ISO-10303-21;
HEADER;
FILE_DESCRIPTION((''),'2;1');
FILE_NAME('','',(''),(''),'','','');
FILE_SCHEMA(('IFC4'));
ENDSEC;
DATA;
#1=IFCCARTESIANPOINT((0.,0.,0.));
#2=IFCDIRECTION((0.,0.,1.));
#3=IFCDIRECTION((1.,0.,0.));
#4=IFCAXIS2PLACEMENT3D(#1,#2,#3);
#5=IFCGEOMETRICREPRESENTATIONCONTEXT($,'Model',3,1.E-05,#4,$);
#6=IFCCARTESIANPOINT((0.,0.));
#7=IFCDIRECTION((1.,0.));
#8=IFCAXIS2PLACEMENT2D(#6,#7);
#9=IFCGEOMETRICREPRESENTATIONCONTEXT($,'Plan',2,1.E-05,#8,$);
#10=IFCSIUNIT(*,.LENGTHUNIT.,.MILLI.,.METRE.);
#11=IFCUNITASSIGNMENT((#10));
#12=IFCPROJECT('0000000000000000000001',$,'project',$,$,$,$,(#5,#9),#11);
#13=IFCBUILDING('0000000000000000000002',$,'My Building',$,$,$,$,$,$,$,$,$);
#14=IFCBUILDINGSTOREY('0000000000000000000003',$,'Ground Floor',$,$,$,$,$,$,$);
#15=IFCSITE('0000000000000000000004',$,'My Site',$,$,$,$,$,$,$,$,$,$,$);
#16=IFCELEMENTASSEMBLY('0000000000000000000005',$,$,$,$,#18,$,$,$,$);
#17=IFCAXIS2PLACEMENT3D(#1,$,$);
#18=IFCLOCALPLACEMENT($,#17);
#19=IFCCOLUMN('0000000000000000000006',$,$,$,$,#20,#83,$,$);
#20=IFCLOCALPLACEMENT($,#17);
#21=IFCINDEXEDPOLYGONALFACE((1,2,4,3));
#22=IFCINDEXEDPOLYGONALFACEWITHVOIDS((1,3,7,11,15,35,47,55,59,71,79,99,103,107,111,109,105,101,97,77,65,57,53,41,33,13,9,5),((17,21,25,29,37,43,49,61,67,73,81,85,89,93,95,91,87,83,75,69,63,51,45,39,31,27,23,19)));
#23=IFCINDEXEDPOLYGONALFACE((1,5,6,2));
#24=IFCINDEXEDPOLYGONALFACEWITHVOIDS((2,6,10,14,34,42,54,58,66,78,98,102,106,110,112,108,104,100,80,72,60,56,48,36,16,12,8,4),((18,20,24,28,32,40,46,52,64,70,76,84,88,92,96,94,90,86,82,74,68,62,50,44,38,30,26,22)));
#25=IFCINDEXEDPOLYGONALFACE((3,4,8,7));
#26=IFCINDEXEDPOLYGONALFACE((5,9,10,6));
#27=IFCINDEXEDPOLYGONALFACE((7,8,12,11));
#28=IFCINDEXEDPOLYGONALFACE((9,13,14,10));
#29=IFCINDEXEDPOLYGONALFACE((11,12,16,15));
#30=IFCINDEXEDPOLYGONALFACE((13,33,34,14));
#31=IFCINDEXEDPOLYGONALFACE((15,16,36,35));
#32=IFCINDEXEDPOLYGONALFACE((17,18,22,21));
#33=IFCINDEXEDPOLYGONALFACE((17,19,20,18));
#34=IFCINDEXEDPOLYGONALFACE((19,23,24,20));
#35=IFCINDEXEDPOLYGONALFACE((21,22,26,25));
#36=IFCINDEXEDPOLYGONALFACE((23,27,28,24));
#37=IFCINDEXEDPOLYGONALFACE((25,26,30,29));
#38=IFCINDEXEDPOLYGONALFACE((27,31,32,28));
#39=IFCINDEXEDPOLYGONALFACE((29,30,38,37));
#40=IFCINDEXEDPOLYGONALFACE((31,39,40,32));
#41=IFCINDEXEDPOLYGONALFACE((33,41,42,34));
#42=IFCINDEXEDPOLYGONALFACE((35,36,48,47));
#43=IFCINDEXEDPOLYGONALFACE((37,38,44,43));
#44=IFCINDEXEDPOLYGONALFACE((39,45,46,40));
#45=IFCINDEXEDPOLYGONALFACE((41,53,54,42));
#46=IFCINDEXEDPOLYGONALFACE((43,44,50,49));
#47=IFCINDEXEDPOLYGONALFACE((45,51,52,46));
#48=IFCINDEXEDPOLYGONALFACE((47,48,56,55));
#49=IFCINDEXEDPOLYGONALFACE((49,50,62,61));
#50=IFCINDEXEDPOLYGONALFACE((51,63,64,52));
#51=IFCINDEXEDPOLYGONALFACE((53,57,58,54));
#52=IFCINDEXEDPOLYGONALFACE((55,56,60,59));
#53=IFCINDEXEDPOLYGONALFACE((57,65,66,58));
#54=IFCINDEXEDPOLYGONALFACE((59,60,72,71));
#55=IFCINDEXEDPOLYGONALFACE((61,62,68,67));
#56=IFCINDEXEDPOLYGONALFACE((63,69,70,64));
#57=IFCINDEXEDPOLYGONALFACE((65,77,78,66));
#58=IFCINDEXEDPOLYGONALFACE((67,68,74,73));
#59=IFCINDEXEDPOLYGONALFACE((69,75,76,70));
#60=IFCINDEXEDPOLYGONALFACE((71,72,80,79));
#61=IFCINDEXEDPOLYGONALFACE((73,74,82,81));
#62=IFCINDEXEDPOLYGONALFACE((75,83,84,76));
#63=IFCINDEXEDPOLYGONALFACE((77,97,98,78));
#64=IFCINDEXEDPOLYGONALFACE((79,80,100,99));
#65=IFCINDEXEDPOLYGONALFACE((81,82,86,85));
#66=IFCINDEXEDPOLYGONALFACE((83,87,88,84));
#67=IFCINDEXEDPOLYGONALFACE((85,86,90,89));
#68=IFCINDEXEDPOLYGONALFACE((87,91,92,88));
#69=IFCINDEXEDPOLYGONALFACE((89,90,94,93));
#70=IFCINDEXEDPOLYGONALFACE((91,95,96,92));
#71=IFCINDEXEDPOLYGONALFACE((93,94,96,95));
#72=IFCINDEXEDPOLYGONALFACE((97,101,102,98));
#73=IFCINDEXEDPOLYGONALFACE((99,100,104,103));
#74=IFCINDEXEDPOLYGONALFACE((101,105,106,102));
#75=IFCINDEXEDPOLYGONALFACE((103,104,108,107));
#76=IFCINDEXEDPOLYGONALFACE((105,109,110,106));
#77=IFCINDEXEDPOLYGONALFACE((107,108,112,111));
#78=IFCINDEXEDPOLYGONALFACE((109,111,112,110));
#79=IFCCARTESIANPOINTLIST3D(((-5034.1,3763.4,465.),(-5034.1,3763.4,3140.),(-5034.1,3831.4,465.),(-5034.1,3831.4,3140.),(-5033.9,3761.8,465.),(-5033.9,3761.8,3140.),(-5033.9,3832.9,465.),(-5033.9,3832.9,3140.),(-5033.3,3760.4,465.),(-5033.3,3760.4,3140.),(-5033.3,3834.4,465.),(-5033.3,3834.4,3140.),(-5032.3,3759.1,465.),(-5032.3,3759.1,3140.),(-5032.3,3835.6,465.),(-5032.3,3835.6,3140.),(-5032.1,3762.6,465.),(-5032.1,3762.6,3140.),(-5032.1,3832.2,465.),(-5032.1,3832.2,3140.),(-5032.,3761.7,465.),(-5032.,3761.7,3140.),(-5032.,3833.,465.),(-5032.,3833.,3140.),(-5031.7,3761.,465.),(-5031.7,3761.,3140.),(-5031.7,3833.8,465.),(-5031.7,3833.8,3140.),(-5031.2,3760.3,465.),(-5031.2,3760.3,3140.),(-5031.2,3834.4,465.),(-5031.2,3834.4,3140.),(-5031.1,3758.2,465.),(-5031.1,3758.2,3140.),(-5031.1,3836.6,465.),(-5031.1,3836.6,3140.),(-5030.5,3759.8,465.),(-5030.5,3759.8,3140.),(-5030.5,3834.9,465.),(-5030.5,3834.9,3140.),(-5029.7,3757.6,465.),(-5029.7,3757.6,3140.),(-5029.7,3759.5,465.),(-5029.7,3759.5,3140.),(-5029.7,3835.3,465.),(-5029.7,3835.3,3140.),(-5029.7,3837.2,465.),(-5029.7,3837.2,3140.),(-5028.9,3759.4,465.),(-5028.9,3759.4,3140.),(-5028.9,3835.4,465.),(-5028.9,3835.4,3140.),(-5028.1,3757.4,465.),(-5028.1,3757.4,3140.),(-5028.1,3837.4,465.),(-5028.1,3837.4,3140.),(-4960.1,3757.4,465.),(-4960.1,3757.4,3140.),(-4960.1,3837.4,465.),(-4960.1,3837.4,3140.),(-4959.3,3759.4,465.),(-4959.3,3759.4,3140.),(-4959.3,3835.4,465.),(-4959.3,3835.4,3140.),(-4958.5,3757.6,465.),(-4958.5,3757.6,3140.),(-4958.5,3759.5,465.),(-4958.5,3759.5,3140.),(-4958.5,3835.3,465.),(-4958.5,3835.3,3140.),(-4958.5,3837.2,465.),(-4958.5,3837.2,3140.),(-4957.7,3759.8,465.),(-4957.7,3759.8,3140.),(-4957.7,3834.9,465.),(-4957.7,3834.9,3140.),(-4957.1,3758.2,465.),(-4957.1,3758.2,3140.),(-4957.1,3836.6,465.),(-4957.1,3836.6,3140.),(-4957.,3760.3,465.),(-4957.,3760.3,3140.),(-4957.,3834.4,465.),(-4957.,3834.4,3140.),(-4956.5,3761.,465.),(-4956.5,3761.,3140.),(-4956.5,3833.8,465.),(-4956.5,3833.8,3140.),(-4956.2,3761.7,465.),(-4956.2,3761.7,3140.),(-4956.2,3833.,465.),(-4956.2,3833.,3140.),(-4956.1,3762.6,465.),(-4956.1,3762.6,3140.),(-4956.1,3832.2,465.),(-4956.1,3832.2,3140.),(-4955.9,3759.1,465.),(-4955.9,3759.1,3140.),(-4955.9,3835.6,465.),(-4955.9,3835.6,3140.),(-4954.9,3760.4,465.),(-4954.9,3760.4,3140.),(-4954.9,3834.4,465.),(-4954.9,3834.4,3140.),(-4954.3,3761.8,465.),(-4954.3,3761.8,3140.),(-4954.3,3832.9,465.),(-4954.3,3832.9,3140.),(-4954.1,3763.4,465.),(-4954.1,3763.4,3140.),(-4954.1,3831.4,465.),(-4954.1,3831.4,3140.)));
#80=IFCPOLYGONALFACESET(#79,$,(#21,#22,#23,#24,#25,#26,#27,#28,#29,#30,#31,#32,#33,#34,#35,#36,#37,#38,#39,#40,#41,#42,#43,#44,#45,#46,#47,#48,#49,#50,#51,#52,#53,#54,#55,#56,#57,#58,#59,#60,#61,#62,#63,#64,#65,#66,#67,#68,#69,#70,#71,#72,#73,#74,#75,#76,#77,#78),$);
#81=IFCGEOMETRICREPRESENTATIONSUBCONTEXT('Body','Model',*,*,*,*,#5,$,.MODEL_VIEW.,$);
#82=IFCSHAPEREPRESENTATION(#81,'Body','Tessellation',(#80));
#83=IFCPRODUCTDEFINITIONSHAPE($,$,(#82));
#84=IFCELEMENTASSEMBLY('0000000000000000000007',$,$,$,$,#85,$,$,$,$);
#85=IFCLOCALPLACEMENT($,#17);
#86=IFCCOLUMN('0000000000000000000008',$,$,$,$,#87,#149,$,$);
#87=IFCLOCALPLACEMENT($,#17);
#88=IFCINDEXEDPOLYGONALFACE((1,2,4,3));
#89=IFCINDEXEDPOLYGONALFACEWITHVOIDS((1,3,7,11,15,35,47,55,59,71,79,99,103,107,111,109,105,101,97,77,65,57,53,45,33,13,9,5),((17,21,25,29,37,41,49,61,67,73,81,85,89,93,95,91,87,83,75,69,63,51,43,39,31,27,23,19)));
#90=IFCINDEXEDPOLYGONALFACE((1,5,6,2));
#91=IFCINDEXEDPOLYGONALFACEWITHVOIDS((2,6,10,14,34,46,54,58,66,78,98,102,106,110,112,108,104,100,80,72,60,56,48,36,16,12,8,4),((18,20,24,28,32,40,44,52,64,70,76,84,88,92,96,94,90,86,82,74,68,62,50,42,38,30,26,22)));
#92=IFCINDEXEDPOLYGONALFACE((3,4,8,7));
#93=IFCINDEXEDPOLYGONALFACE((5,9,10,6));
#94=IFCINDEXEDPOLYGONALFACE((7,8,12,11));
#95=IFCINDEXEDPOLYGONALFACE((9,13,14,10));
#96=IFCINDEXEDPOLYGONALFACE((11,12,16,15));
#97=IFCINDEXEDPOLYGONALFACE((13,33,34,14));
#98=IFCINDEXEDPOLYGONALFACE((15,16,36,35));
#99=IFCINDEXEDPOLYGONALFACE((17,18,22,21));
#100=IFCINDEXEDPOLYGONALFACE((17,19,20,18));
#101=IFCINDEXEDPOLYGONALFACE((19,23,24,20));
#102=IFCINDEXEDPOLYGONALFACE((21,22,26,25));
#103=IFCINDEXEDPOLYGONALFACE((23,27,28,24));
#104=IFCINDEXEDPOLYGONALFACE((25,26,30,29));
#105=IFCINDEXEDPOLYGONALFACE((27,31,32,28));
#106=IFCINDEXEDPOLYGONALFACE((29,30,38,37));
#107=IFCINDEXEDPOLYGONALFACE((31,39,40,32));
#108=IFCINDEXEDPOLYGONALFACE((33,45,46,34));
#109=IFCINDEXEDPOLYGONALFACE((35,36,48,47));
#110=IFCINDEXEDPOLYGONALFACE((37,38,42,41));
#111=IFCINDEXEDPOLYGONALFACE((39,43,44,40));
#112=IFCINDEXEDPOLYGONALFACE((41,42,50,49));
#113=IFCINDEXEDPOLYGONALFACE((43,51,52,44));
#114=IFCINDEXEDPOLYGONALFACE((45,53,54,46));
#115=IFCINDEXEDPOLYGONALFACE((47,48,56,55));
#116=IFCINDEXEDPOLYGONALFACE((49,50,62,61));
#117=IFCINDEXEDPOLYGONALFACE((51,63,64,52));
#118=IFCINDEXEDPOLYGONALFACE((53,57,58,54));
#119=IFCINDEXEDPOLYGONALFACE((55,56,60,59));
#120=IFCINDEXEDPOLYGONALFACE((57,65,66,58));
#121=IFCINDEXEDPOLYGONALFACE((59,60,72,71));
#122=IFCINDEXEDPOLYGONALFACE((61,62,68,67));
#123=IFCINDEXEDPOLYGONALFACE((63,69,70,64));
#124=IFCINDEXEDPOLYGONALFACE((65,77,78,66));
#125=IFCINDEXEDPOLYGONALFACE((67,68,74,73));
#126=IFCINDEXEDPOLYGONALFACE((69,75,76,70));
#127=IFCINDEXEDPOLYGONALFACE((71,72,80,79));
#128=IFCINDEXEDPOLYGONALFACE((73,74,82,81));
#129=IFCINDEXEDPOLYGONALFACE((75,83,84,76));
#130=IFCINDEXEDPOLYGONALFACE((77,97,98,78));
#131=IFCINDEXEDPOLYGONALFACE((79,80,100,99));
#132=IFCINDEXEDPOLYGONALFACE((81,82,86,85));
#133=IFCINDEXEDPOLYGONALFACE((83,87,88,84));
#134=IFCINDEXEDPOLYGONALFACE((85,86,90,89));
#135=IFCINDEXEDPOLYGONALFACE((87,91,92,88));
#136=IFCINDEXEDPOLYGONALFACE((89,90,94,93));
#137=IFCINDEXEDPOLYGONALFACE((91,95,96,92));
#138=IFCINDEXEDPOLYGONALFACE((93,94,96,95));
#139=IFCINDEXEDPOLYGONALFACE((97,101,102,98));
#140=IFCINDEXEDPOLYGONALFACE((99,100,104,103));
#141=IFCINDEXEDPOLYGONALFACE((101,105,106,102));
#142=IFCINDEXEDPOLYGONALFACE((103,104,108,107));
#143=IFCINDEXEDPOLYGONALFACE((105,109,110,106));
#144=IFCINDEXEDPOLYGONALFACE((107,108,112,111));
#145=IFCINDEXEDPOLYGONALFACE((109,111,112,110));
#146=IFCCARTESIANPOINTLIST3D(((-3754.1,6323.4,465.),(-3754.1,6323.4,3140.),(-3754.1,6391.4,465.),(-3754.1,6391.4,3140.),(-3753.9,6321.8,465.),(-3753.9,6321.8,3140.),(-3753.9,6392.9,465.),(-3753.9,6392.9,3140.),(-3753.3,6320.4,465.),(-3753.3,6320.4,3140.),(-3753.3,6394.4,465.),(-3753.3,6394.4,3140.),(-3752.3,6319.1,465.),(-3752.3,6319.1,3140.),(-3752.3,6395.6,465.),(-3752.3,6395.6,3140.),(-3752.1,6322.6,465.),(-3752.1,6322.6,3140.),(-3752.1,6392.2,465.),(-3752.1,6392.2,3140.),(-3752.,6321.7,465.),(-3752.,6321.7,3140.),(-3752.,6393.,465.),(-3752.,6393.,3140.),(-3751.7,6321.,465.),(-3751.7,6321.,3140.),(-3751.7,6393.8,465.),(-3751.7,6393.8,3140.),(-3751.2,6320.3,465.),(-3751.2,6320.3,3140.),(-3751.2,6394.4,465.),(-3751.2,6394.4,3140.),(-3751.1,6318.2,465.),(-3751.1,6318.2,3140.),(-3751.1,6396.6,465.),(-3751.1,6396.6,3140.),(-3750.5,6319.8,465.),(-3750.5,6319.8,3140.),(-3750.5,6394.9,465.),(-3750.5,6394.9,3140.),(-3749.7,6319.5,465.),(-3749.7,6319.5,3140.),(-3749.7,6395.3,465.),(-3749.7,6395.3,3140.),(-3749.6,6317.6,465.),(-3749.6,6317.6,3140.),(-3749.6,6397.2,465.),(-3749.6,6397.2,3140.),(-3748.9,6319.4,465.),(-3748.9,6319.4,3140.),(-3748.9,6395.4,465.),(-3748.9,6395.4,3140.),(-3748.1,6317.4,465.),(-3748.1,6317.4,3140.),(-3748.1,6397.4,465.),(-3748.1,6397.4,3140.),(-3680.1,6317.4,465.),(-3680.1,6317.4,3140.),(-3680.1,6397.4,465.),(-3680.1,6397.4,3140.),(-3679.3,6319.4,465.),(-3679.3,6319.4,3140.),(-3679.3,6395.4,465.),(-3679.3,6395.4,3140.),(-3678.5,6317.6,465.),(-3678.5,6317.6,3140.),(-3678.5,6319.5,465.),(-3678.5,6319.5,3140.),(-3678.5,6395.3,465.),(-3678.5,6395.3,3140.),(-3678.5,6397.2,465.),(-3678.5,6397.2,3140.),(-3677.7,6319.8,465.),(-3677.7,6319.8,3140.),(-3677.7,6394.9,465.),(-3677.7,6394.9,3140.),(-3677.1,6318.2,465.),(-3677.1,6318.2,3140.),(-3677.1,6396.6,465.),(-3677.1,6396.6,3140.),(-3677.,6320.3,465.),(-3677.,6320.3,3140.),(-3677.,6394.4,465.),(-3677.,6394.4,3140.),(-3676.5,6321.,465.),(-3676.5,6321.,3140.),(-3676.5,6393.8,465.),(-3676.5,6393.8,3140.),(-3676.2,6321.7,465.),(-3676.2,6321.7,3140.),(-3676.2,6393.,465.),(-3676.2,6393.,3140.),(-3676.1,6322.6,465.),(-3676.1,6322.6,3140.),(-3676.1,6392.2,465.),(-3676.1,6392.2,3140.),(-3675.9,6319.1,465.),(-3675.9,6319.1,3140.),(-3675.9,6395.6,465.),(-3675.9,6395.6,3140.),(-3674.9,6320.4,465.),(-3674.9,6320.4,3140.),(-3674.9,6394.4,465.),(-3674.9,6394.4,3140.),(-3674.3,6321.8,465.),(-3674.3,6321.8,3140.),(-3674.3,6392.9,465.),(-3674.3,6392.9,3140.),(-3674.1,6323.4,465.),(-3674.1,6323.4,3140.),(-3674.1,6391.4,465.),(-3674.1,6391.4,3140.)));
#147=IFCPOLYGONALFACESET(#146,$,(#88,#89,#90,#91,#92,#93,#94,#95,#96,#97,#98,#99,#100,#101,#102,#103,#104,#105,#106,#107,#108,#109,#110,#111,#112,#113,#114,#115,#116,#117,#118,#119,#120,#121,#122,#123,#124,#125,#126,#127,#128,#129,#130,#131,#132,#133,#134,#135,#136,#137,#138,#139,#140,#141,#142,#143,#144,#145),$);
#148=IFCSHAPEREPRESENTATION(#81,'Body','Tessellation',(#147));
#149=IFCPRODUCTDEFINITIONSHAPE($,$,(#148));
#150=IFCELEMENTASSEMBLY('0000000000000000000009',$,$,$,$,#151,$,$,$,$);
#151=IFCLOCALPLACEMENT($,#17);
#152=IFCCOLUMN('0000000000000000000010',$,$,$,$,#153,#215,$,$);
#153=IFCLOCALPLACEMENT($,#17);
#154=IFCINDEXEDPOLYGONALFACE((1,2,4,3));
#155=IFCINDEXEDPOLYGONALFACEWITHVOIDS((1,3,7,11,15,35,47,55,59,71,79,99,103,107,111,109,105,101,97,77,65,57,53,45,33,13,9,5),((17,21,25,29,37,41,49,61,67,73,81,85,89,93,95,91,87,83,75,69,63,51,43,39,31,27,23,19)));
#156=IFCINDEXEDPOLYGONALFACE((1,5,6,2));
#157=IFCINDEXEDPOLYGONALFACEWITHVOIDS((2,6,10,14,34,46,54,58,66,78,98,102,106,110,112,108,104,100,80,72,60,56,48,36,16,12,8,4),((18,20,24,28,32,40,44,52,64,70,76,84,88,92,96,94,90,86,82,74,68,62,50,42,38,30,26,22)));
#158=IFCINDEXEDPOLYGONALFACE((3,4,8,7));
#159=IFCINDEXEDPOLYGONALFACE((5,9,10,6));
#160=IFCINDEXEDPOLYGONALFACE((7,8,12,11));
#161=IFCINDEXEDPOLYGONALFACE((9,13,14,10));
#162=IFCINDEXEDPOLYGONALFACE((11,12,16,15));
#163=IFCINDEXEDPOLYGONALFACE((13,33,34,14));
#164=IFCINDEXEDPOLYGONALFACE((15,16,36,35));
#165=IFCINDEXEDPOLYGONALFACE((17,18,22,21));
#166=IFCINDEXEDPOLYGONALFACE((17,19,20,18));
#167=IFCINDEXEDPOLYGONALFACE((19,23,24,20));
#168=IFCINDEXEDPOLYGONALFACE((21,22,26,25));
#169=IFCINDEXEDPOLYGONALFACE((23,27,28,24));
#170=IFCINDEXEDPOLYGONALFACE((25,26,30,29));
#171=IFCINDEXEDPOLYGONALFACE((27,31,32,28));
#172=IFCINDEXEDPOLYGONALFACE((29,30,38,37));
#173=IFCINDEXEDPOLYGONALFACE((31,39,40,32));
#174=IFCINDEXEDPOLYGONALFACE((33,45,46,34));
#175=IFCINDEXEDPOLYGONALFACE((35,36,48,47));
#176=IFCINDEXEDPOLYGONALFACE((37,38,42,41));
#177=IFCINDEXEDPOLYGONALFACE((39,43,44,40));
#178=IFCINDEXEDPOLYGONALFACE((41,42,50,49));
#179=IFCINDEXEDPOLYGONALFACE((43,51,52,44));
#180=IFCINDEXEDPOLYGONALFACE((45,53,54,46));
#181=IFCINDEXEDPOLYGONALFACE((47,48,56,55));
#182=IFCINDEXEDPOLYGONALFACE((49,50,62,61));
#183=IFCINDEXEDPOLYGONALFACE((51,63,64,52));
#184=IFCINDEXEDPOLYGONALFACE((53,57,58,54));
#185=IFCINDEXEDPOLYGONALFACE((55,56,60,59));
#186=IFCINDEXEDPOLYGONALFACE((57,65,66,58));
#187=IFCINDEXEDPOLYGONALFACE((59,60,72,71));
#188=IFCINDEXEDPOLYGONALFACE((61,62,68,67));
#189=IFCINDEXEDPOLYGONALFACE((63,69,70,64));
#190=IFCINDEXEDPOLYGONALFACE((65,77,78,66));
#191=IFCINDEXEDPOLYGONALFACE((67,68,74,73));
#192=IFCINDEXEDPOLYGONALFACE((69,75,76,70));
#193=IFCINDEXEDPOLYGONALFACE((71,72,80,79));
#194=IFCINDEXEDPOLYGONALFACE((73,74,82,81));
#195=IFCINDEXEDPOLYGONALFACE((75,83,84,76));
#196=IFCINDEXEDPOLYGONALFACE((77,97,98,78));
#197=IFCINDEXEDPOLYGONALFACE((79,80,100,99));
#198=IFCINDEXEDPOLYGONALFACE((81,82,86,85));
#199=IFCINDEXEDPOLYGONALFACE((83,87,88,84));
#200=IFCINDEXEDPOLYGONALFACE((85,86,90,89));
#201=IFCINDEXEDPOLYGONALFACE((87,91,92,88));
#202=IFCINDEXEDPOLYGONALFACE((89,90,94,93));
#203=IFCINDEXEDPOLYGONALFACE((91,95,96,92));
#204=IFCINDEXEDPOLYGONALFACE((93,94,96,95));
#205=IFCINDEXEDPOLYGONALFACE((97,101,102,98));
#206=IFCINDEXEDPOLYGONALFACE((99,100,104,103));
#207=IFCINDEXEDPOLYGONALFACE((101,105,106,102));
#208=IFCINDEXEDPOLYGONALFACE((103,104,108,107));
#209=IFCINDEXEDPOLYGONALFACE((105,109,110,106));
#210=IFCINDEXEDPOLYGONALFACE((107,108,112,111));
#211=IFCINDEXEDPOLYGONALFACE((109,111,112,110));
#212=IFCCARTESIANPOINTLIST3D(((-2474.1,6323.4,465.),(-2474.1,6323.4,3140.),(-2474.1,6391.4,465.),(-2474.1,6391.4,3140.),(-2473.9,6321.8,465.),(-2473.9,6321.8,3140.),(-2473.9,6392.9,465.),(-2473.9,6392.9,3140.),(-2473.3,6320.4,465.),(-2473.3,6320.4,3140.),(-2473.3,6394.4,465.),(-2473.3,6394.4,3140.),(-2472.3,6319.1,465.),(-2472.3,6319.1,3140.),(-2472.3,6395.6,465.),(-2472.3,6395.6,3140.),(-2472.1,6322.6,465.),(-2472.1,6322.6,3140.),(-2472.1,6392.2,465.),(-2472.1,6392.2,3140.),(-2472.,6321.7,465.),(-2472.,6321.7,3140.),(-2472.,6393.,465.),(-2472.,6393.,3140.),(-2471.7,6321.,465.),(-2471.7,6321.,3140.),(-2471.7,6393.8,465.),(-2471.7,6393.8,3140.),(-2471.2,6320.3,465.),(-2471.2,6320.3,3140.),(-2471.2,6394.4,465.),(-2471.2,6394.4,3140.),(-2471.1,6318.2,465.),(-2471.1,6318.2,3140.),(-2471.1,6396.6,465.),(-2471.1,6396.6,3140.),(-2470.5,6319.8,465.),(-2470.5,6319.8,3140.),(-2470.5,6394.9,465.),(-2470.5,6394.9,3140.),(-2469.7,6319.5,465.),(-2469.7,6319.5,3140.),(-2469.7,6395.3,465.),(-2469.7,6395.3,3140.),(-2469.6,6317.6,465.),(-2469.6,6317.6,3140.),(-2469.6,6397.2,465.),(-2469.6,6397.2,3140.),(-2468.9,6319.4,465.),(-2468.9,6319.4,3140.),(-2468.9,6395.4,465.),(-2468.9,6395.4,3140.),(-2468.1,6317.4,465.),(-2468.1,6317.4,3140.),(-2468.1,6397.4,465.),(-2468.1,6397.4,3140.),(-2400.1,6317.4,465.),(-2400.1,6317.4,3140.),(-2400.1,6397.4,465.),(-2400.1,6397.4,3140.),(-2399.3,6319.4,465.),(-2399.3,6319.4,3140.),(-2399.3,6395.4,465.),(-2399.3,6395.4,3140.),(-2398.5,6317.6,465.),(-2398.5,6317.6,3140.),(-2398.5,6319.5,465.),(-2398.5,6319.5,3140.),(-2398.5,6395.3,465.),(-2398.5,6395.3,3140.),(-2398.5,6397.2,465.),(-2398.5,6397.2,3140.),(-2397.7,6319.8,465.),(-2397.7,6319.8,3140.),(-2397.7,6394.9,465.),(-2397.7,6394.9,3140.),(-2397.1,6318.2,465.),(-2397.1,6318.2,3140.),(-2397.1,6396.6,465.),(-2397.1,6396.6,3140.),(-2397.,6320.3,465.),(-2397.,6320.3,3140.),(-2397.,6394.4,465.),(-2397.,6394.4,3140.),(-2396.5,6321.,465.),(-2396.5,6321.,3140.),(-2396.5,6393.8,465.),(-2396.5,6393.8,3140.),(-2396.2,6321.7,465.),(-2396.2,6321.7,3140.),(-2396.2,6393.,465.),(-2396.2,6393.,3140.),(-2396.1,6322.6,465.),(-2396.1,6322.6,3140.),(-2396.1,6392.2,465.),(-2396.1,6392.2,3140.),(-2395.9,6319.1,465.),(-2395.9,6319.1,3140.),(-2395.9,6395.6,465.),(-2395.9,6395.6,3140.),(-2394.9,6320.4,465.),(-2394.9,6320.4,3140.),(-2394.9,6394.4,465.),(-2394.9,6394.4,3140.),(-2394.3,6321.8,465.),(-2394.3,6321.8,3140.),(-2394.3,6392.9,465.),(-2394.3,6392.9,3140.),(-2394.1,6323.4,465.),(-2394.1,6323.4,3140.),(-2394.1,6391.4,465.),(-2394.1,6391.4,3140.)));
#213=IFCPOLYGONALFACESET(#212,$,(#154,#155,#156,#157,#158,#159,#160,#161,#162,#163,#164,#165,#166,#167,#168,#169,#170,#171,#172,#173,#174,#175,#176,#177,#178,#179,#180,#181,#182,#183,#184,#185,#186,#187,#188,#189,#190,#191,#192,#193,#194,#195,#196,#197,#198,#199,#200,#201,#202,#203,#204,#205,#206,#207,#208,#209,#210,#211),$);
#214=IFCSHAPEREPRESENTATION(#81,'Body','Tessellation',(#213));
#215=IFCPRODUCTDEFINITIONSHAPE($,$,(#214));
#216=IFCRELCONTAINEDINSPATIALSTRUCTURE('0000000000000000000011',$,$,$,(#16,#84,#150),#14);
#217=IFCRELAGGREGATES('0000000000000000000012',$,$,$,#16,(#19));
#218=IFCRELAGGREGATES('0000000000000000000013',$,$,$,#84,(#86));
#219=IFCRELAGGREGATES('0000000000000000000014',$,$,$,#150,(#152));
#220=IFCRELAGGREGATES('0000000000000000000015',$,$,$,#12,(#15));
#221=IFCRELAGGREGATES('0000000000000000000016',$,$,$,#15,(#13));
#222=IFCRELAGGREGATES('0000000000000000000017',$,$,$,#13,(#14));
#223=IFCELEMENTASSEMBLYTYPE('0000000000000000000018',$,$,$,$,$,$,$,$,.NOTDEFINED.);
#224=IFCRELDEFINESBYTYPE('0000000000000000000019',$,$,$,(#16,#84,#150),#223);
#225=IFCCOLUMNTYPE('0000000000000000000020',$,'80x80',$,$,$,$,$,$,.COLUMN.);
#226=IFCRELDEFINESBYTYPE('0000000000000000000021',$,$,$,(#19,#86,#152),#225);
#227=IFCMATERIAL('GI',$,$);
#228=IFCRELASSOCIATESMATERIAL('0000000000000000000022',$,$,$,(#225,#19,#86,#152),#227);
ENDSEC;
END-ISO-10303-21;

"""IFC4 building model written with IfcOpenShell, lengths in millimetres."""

from ifc_helpers import new_model, si_unit, frame, origin_with_axes, origin_2d_with_axis, place, context, subcontext, project, spatial, hollow_rectangle, extrude, material, material_profile, profile_set, profile_usage, type_object, element, aggregate, save


model = new_model("IFC4")

# Units and contexts
model_context = context("Model", 3, precision=1e-05, world=origin_with_axes())
plan_context = context("Plan", 2, precision=1e-05, world=origin_2d_with_axis())
body_context = subcontext(model_context, "Body", "Model", "MODEL_VIEW")
ifc_project = project(units=[si_unit("LENGTHUNIT", "METRE", prefix="MILLI")], contexts=[model_context, plan_context])

# Site, building, storey
site = spatial("IfcSite", under=ifc_project, Name="My Site")
building = spatial("IfcBuilding", under=site, Name="My Building")
storey = spatial("IfcBuildingStorey", under=building, Name="Ground Floor")

# Element assemblies, columns
element_assembly_type_1 = type_object("IfcElementAssemblyType", PredefinedType="NOTDEFINED")
ifc_material = material(Name="GI")
ifc_material_profile_1 = material_profile(ifc_material, hollow_rectangle(XDim=80.0, YDim=80.0, WallThickness=2.0, InnerFilletRadius=3.2, OuterFilletRadius=6.0))
ifc_profile_set_1 = profile_set([ifc_material_profile_1], Name="80x80 GI Rectangular Hollow")
column_type = type_object("IfcColumnType", Name="80x80", PredefinedType="COLUMN", material=ifc_profile_set_1)
assembly_1_placement = place(None, frame((-4994.1, 3797.4, 465.0), z_axis=(0.0, 0.0, 1.0), x_axis=(1.0, 0.0, 0.0)))
assembly_1 = element("IfcElementAssembly", 1, at=assembly_1_placement, inside=storey, type_object=element_assembly_type_1)
ifc_profile_usage_1 = profile_usage(ifc_profile_set_1)
column_1_placement = place(assembly_1_placement, origin_with_axes())
column_1 = element("IfcColumn", 2, at=column_1_placement, type_object=column_type, material=ifc_profile_usage_1, context=body_context, shape_type="SweptSolid", body=[
    extrude(hollow_rectangle(XDim=80.0, YDim=80.0, WallThickness=2.0, InnerFilletRadius=3.2, OuterFilletRadius=6.0), origin_with_axes(), (0.0, 0.0, 1.0), 2675.0),
])
aggregate(assembly_1, [column_1])
assembly_2_placement = place(None, frame((-3714.1, 6357.4, 465.0), z_axis=(0.0, 0.0, 1.0), x_axis=(1.0, 0.0, 0.0)))
assembly_2 = element("IfcElementAssembly", 3, at=assembly_2_placement, inside=storey, type_object=element_assembly_type_1)
ifc_profile_usage_2 = profile_usage(ifc_profile_set_1)
column_2_placement = place(assembly_2_placement, origin_with_axes())
column_2 = element("IfcColumn", 4, at=column_2_placement, type_object=column_type, material=ifc_profile_usage_2, context=body_context, shape_type="SweptSolid", body=[
    extrude(hollow_rectangle(XDim=80.0, YDim=80.0, WallThickness=2.0, InnerFilletRadius=3.2, OuterFilletRadius=6.0), origin_with_axes(), (0.0, 0.0, 1.0), 2675.0),
])
aggregate(assembly_2, [column_2])
assembly_3_placement = place(None, frame((-2434.1, 6357.4, 465.0), z_axis=(0.0, 0.0, 1.0), x_axis=(1.0, 0.0, 0.0)))
assembly_3 = element("IfcElementAssembly", 5, at=assembly_3_placement, inside=storey, type_object=element_assembly_type_1)
ifc_profile_usage_3 = profile_usage(ifc_profile_set_1)
column_3_placement = place(assembly_3_placement, origin_with_axes())
column_3 = element("IfcColumn", 6, at=column_3_placement, type_object=column_type, material=ifc_profile_usage_3, context=body_context, shape_type="SweptSolid", body=[
    extrude(hollow_rectangle(XDim=80.0, YDim=80.0, WallThickness=2.0, InnerFilletRadius=3.2, OuterFilletRadius=6.0), origin_with_axes(), (0.0, 0.0, 1.0), 2675.0),
])
aggregate(assembly_3, [column_3])

save(model, "model.ifc")
